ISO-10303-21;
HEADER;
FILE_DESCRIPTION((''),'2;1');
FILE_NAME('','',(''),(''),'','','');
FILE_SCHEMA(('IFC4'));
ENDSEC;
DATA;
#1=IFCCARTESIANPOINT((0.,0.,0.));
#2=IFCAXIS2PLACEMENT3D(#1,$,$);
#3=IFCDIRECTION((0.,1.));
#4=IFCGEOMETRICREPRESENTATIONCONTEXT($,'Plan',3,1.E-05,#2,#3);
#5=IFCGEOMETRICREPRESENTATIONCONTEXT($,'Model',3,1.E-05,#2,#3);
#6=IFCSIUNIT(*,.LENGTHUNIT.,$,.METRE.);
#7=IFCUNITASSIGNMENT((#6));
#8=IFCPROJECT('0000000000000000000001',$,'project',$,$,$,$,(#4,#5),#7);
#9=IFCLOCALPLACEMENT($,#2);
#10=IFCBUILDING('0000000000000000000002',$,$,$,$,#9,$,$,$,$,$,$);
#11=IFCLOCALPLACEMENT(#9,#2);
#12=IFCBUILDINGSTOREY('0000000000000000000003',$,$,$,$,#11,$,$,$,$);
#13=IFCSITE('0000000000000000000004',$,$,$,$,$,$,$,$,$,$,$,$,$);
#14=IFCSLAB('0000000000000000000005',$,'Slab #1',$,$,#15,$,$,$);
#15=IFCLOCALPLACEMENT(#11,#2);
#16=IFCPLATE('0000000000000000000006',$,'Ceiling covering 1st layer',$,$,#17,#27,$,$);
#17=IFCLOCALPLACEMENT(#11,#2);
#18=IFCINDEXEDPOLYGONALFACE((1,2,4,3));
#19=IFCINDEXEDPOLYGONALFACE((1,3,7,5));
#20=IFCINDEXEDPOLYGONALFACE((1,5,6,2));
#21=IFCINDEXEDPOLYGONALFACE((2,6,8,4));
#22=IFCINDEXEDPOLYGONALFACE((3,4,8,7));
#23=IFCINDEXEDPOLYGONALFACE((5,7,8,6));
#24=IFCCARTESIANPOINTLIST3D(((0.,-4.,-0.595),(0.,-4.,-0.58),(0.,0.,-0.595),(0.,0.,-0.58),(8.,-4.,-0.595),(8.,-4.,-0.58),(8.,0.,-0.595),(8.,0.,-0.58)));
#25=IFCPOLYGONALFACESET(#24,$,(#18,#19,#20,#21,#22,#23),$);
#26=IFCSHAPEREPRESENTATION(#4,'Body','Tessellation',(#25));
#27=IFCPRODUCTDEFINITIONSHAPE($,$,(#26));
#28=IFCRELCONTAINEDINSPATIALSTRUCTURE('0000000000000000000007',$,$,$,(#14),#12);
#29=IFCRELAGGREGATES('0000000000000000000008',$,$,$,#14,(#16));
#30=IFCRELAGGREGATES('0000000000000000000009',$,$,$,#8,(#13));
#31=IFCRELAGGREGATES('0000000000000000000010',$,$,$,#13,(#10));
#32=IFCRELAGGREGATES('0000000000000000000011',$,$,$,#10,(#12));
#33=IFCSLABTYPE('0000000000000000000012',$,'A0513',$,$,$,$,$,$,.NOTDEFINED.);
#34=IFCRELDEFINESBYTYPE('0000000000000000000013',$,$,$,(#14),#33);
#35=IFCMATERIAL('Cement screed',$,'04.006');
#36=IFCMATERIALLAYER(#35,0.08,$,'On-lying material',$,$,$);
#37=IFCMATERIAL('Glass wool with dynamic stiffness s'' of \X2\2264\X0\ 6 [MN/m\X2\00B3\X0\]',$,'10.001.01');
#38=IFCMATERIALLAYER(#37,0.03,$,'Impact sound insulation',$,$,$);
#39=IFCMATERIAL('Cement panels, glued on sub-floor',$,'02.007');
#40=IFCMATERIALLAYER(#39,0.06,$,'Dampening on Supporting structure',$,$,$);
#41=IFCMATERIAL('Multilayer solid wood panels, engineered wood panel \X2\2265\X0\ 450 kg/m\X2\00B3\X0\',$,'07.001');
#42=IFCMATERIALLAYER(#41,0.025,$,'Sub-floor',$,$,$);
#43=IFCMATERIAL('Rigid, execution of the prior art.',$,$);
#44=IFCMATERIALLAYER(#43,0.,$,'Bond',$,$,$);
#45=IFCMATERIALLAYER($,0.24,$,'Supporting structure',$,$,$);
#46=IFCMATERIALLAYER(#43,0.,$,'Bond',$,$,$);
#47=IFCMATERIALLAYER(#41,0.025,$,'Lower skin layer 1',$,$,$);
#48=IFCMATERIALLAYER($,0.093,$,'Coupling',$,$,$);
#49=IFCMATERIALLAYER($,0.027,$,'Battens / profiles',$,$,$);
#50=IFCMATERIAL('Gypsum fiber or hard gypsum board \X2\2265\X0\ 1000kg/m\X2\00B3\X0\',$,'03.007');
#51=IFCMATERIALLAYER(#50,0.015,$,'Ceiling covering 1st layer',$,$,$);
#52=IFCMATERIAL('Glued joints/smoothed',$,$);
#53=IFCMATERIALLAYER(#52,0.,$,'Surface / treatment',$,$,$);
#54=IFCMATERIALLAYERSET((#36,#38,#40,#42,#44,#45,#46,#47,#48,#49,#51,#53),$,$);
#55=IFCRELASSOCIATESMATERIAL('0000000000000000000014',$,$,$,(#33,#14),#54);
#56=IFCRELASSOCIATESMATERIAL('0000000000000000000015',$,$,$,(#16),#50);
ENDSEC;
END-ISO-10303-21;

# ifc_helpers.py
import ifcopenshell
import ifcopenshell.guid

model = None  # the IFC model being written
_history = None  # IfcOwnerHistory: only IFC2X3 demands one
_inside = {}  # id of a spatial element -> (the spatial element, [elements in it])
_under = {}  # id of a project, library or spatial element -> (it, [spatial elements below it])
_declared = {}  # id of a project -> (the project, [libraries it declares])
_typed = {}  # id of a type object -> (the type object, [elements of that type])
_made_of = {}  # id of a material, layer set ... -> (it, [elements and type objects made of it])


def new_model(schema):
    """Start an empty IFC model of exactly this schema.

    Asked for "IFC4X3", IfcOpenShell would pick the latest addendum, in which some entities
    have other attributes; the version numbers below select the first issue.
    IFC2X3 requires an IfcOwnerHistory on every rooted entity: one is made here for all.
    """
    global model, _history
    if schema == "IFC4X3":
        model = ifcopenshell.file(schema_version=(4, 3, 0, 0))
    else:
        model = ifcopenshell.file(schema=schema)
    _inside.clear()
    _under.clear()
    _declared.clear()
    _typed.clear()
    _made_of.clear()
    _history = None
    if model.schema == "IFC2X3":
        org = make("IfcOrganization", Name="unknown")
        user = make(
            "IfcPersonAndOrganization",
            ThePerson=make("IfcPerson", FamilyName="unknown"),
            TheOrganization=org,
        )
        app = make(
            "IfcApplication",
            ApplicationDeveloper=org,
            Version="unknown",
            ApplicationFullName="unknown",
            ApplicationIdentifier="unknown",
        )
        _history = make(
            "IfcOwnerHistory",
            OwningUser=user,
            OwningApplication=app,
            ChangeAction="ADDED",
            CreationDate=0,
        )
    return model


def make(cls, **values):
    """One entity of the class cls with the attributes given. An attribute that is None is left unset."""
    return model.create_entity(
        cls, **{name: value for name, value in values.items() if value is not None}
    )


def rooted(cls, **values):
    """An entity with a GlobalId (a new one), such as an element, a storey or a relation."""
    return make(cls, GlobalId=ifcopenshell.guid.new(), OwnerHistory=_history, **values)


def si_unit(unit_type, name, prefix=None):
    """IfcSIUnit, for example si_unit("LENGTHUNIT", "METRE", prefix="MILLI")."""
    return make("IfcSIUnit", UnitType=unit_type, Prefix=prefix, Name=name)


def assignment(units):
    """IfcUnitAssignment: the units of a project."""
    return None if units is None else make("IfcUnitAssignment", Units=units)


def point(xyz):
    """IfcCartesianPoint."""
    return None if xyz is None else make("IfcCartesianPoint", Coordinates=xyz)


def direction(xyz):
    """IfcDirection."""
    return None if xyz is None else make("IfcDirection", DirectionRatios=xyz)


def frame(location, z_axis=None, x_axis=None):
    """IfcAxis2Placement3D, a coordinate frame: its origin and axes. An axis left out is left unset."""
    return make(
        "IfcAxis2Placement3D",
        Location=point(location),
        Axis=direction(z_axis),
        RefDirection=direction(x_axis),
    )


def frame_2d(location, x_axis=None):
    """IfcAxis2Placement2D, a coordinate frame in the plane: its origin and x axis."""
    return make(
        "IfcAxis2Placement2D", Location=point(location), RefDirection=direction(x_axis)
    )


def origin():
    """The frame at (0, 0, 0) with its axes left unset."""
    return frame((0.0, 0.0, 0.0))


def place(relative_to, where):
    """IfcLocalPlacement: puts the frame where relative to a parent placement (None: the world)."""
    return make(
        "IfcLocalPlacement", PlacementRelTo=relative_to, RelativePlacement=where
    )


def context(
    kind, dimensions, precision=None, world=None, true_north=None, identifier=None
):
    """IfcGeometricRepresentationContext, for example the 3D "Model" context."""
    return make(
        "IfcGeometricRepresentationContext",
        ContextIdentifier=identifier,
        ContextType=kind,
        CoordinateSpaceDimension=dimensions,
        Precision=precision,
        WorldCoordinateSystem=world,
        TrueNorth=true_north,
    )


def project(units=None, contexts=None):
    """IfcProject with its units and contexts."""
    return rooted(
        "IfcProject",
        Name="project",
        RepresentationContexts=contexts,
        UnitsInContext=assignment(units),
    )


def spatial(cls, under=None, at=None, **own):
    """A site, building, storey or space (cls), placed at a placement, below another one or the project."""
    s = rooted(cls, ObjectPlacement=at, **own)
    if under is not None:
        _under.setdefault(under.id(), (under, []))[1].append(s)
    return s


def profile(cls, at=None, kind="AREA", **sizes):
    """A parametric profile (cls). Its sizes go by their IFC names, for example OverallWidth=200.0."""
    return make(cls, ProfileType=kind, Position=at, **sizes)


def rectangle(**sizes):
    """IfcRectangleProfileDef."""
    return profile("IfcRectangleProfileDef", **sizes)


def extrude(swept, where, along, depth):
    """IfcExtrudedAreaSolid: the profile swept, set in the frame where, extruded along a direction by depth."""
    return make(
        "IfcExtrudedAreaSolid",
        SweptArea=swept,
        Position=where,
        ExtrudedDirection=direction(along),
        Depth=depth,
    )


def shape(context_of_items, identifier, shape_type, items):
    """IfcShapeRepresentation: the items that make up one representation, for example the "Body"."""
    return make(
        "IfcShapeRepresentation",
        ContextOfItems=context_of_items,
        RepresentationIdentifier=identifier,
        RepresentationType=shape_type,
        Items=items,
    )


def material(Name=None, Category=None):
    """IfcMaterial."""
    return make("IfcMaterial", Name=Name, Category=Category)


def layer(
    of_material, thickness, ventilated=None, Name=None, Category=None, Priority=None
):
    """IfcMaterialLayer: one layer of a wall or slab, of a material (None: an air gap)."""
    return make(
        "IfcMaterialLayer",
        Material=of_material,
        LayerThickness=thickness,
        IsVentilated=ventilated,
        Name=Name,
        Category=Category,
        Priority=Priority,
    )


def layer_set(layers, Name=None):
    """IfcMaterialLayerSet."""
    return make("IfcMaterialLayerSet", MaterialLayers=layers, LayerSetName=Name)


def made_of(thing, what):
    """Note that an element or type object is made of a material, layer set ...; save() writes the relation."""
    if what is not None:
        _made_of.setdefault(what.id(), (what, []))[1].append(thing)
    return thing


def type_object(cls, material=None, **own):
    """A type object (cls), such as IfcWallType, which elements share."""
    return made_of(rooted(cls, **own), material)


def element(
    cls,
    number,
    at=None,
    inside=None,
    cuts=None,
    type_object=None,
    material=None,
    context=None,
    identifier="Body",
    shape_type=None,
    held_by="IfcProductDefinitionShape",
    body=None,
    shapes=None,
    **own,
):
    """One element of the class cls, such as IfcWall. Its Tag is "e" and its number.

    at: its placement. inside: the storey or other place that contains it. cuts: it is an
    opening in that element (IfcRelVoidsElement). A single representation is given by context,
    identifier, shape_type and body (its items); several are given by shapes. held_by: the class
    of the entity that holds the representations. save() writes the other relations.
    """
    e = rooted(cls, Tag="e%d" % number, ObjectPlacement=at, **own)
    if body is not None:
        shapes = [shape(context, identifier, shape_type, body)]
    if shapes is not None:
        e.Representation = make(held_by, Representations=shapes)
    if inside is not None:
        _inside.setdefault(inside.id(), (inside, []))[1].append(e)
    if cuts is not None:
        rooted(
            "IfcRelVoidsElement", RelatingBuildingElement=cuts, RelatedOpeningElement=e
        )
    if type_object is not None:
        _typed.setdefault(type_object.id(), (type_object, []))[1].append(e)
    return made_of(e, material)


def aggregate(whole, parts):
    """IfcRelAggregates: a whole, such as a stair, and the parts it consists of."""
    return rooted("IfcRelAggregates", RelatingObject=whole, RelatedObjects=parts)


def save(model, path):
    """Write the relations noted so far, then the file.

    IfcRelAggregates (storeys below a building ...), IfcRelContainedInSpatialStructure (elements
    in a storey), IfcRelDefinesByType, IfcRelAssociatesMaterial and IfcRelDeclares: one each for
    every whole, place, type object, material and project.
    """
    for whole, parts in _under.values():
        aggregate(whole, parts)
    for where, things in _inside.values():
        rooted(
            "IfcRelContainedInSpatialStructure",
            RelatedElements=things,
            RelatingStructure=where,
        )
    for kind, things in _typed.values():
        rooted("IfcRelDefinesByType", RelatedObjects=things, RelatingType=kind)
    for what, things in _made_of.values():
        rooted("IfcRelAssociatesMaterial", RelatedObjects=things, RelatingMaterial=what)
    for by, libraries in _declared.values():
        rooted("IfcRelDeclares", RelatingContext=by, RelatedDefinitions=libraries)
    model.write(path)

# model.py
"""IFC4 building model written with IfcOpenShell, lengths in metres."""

from ifc_helpers import new_model, si_unit, direction, frame, frame_2d, origin, place, context, project, spatial, rectangle, extrude, material, layer, layer_set, type_object, element, aggregate, save


model = new_model("IFC4")

# Units and contexts
plan_context = context("Plan", 3, precision=1e-05, world=origin(), true_north=direction((0.0, 1.0)))
model_context = context("Model", 3, precision=1e-05, world=origin(), true_north=direction((0.0, 1.0)))
ifc_project = project(units=[si_unit("LENGTHUNIT", "METRE")], contexts=[plan_context, model_context])

# Site, building, storey
site = spatial("IfcSite", under=ifc_project)
building_placement = place(None, origin())
building = spatial("IfcBuilding", under=site, at=building_placement)
storey_placement = place(building_placement, origin())
storey = spatial("IfcBuildingStorey", under=building, at=storey_placement)

# Slab, plate
ifc_material_1 = material(Name="Cement screed", Category="04.006")
ifc_layer_1 = layer(ifc_material_1, 0.08, Name="On-lying material")
ifc_material_2 = material(Name="Glass wool with dynamic stiffness s' of ≤ 6 [MN/m³]", Category="10.001.01")
ifc_layer_2 = layer(ifc_material_2, 0.03, Name="Impact sound insulation")
ifc_material_3 = material(Name="Cement panels, glued on sub-floor", Category="02.007")
ifc_layer_3 = layer(ifc_material_3, 0.06, Name="Dampening on Supporting structure")
ifc_material_4 = material(Name="Multilayer solid wood panels, engineered wood panel ≥ 450 kg/m³", Category="07.001")
ifc_layer_4 = layer(ifc_material_4, 0.025, Name="Sub-floor")
ifc_material_5 = material(Name="Rigid, execution of the prior art.")
ifc_layer_5 = layer(ifc_material_5, 0.0, Name="Bond")
ifc_layer_6 = layer(None, 0.24, Name="Supporting structure")
ifc_layer_7 = layer(ifc_material_5, 0.0, Name="Bond")
ifc_layer_8 = layer(ifc_material_4, 0.025, Name="Lower skin layer 1")
ifc_layer_9 = layer(None, 0.093, Name="Coupling")
ifc_layer_10 = layer(None, 0.027, Name="Battens / profiles")
ifc_material_6 = material(Name="Gypsum fiber or hard gypsum board ≥ 1000kg/m³", Category="03.007")
ifc_layer_11 = layer(ifc_material_6, 0.015, Name="Ceiling covering 1st layer")
ifc_material_7 = material(Name="Glued joints/smoothed")
ifc_layer_12 = layer(ifc_material_7, 0.0, Name="Surface / treatment")
ifc_layer_set = layer_set([ifc_layer_1, ifc_layer_2, ifc_layer_3, ifc_layer_4, ifc_layer_5, ifc_layer_6, ifc_layer_7, ifc_layer_8, ifc_layer_9, ifc_layer_10, ifc_layer_11, ifc_layer_12])
slab_type = type_object("IfcSlabType", Name="A0513", PredefinedType="NOTDEFINED", material=ifc_layer_set)
slab_placement = place(None, frame((0.0, 0.0, 0.0), z_axis=(0.0, 0.0, -1.0), x_axis=(1.0, 0.0, 0.0)))
slab = element("IfcSlab", 1, at=slab_placement, inside=storey, type_object=slab_type, material=ifc_layer_set, Name="Slab #1")
plate_1_placement = place(slab_placement, origin())
plate_1 = element("IfcPlate", 2, at=plate_1_placement, material=ifc_material_6, Name="Ceiling covering 1st layer", context=plan_context, shape_type="SweptSolid", body=[
    extrude(rectangle(XDim=8.0, YDim=4.0, at=frame_2d((4.0, 2.0), x_axis=(1.0, 0.0))), frame((0.0, 0.0, 0.58), z_axis=(0.0, 0.0, 1.0), x_axis=(1.0, 0.0, 0.0)), (0.0, 0.0, 1.0), 0.015),
])
aggregate(slab, [plate_1])

save(model, "model.ifc")
